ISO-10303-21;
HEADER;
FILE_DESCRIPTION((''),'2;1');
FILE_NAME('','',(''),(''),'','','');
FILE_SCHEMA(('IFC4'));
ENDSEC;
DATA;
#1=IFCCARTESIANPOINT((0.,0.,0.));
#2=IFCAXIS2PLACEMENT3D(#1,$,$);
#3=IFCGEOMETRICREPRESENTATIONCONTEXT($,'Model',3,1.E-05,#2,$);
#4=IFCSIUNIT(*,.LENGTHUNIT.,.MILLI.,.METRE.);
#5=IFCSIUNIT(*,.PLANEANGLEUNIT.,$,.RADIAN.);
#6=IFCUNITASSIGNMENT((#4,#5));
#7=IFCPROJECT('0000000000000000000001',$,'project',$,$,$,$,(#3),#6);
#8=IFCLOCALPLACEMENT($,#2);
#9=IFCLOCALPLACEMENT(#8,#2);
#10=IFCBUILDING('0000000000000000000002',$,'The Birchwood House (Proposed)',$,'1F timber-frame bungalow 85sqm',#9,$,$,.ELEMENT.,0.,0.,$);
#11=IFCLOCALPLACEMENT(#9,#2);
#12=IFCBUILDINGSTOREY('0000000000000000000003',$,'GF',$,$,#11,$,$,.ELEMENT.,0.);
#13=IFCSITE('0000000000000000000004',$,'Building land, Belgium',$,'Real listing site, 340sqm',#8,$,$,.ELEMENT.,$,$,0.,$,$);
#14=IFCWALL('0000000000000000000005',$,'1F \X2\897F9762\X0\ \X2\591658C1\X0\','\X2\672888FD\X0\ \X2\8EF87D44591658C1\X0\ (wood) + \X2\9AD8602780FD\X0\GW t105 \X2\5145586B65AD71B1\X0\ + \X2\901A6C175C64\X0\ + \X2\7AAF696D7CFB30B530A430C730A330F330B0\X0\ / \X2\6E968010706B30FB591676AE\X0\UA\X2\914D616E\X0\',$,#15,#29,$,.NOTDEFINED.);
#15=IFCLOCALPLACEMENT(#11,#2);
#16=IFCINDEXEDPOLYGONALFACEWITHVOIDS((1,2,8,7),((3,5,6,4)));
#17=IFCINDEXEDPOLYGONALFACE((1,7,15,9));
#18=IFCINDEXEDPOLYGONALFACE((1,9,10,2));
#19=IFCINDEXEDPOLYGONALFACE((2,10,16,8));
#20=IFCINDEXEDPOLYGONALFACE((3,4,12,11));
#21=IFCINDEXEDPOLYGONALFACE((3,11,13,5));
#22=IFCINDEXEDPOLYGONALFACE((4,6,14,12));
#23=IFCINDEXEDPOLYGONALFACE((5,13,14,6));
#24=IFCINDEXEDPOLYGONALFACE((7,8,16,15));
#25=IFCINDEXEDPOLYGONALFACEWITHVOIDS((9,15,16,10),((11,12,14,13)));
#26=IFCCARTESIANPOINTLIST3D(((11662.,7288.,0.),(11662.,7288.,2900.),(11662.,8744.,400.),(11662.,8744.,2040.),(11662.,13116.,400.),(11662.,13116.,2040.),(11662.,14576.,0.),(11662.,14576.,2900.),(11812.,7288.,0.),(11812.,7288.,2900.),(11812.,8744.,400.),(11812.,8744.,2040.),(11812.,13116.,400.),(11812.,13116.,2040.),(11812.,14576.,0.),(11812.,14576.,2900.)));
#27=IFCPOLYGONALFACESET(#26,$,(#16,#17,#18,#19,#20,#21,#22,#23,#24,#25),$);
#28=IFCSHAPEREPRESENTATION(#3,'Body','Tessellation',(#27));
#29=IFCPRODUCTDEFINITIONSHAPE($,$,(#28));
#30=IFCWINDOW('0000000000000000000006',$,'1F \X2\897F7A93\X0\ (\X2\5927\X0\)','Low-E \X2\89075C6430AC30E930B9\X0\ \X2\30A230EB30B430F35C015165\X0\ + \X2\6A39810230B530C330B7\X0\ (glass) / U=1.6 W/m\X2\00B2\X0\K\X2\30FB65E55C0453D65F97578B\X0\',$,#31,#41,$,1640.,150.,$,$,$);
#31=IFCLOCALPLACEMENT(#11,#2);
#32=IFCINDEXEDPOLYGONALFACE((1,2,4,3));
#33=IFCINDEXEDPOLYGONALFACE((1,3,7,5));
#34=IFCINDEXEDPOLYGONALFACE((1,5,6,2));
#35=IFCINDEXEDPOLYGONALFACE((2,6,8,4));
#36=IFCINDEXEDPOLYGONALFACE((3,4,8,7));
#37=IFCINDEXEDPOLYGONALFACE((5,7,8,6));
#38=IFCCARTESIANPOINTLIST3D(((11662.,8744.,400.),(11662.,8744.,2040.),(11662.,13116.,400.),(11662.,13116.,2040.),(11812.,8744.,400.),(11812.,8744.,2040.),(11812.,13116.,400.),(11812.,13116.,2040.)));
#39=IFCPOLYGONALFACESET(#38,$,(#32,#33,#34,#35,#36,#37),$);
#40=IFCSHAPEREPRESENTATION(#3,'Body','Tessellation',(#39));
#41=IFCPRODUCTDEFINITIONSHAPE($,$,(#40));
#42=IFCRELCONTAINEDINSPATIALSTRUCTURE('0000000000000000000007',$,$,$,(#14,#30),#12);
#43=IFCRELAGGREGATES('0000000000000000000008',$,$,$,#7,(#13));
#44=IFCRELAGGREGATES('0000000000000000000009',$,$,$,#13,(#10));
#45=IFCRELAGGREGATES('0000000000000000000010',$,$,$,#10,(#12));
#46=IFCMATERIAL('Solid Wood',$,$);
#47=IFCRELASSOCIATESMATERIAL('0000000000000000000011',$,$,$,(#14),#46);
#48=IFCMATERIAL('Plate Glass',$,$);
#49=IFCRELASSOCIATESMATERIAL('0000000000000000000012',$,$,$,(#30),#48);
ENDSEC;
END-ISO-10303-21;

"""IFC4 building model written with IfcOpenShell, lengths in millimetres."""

from ifc_helpers import new_model, si_unit, frame, frame_2d, origin, place, context, project, spatial, rectangle, extrude, material, element, fill, save


model = new_model("IFC4")

# Units and contexts
model_context = context("Model", 3, precision=1e-05, world=origin())
ifc_project = project(units=[si_unit("LENGTHUNIT", "METRE", prefix="MILLI"), si_unit("PLANEANGLEUNIT", "RADIAN")], contexts=[model_context])

# Site, building, storey
site_placement = place(None, origin())
site = spatial("IfcSite", under=ifc_project, at=site_placement, Name="Building land, Belgium", ObjectType="Real listing site, 340sqm", CompositionType="ELEMENT", RefElevation=0.0)
building_placement = place(site_placement, origin())
building = spatial("IfcBuilding", under=site, at=building_placement, Name="The Birchwood House (Proposed)", ObjectType="1F timber-frame bungalow 85sqm", CompositionType="ELEMENT", ElevationOfRefHeight=0.0, ElevationOfTerrain=0.0)
storey_placement = place(building_placement, origin())
storey = spatial("IfcBuildingStorey", under=building, at=storey_placement, Name="GF", CompositionType="ELEMENT", Elevation=0.0)

# Shared definitions
ifc_material_1 = material(Name="Solid Wood")

# Shared definitions
ifc_material_2 = material(Name="Plate Glass")

# Wall, opening, window
wall_1_placement = place(storey_placement, frame((5831.0, 3644.0, 0.0)))
wall_1 = element("IfcWall", 1, at=wall_1_placement, inside=storey, material=ifc_material_1, Name="1F 西面 外壁", Description="木製 軸組外壁 (wood) + 高性能GW t105 充填断熱 + 通気層 + 窯業系サイディング / 準耐火・外皮UA配慮", PredefinedType="NOTDEFINED", context=model_context, shape_type="SweptSolid", body=[
    extrude(rectangle(XDim=150.0, YDim=7288.0, at=frame_2d((75.0, 3644.0))), frame((5831.0, 3644.0, 0.0)), (0.0, 0.0, 1.0), 2900.0),
])
opening_1_placement = place(storey_placement, frame((5831.0, 4372.0, 200.0)))
opening_1 = element("IfcOpeningElement", 2, at=opening_1_placement, cuts=wall_1, PredefinedType="NOTDEFINED", context=model_context, shape_type="SweptSolid", body=[
    extrude(rectangle(XDim=150.0, YDim=4372.0, at=frame_2d((75.0, 2186.0))), frame((5831.0, 4372.0, 200.0)), (0.0, 0.0, 1.0), 1640.0),
])
window_1_placement = place(storey_placement, frame((5831.0, 4372.0, 200.0)))
window_1 = element("IfcWindow", 3, at=window_1_placement, inside=storey, material=ifc_material_2, Name="1F 西窓 (大)", Description="Low-E 複層ガラス アルゴン封入 + 樹脂サッシ (glass) / U=1.6 W/m²K・日射取得型", OverallHeight=1640.0, OverallWidth=150.0, context=model_context, shape_type="SweptSolid", body=[
    extrude(rectangle(XDim=150.0, YDim=4372.0, at=frame_2d((75.0, 2186.0))), frame((5831.0, 4372.0, 200.0)), (0.0, 0.0, 1.0), 1640.0),
])
fill(opening_1, window_1)

save(model, "model.ifc")
